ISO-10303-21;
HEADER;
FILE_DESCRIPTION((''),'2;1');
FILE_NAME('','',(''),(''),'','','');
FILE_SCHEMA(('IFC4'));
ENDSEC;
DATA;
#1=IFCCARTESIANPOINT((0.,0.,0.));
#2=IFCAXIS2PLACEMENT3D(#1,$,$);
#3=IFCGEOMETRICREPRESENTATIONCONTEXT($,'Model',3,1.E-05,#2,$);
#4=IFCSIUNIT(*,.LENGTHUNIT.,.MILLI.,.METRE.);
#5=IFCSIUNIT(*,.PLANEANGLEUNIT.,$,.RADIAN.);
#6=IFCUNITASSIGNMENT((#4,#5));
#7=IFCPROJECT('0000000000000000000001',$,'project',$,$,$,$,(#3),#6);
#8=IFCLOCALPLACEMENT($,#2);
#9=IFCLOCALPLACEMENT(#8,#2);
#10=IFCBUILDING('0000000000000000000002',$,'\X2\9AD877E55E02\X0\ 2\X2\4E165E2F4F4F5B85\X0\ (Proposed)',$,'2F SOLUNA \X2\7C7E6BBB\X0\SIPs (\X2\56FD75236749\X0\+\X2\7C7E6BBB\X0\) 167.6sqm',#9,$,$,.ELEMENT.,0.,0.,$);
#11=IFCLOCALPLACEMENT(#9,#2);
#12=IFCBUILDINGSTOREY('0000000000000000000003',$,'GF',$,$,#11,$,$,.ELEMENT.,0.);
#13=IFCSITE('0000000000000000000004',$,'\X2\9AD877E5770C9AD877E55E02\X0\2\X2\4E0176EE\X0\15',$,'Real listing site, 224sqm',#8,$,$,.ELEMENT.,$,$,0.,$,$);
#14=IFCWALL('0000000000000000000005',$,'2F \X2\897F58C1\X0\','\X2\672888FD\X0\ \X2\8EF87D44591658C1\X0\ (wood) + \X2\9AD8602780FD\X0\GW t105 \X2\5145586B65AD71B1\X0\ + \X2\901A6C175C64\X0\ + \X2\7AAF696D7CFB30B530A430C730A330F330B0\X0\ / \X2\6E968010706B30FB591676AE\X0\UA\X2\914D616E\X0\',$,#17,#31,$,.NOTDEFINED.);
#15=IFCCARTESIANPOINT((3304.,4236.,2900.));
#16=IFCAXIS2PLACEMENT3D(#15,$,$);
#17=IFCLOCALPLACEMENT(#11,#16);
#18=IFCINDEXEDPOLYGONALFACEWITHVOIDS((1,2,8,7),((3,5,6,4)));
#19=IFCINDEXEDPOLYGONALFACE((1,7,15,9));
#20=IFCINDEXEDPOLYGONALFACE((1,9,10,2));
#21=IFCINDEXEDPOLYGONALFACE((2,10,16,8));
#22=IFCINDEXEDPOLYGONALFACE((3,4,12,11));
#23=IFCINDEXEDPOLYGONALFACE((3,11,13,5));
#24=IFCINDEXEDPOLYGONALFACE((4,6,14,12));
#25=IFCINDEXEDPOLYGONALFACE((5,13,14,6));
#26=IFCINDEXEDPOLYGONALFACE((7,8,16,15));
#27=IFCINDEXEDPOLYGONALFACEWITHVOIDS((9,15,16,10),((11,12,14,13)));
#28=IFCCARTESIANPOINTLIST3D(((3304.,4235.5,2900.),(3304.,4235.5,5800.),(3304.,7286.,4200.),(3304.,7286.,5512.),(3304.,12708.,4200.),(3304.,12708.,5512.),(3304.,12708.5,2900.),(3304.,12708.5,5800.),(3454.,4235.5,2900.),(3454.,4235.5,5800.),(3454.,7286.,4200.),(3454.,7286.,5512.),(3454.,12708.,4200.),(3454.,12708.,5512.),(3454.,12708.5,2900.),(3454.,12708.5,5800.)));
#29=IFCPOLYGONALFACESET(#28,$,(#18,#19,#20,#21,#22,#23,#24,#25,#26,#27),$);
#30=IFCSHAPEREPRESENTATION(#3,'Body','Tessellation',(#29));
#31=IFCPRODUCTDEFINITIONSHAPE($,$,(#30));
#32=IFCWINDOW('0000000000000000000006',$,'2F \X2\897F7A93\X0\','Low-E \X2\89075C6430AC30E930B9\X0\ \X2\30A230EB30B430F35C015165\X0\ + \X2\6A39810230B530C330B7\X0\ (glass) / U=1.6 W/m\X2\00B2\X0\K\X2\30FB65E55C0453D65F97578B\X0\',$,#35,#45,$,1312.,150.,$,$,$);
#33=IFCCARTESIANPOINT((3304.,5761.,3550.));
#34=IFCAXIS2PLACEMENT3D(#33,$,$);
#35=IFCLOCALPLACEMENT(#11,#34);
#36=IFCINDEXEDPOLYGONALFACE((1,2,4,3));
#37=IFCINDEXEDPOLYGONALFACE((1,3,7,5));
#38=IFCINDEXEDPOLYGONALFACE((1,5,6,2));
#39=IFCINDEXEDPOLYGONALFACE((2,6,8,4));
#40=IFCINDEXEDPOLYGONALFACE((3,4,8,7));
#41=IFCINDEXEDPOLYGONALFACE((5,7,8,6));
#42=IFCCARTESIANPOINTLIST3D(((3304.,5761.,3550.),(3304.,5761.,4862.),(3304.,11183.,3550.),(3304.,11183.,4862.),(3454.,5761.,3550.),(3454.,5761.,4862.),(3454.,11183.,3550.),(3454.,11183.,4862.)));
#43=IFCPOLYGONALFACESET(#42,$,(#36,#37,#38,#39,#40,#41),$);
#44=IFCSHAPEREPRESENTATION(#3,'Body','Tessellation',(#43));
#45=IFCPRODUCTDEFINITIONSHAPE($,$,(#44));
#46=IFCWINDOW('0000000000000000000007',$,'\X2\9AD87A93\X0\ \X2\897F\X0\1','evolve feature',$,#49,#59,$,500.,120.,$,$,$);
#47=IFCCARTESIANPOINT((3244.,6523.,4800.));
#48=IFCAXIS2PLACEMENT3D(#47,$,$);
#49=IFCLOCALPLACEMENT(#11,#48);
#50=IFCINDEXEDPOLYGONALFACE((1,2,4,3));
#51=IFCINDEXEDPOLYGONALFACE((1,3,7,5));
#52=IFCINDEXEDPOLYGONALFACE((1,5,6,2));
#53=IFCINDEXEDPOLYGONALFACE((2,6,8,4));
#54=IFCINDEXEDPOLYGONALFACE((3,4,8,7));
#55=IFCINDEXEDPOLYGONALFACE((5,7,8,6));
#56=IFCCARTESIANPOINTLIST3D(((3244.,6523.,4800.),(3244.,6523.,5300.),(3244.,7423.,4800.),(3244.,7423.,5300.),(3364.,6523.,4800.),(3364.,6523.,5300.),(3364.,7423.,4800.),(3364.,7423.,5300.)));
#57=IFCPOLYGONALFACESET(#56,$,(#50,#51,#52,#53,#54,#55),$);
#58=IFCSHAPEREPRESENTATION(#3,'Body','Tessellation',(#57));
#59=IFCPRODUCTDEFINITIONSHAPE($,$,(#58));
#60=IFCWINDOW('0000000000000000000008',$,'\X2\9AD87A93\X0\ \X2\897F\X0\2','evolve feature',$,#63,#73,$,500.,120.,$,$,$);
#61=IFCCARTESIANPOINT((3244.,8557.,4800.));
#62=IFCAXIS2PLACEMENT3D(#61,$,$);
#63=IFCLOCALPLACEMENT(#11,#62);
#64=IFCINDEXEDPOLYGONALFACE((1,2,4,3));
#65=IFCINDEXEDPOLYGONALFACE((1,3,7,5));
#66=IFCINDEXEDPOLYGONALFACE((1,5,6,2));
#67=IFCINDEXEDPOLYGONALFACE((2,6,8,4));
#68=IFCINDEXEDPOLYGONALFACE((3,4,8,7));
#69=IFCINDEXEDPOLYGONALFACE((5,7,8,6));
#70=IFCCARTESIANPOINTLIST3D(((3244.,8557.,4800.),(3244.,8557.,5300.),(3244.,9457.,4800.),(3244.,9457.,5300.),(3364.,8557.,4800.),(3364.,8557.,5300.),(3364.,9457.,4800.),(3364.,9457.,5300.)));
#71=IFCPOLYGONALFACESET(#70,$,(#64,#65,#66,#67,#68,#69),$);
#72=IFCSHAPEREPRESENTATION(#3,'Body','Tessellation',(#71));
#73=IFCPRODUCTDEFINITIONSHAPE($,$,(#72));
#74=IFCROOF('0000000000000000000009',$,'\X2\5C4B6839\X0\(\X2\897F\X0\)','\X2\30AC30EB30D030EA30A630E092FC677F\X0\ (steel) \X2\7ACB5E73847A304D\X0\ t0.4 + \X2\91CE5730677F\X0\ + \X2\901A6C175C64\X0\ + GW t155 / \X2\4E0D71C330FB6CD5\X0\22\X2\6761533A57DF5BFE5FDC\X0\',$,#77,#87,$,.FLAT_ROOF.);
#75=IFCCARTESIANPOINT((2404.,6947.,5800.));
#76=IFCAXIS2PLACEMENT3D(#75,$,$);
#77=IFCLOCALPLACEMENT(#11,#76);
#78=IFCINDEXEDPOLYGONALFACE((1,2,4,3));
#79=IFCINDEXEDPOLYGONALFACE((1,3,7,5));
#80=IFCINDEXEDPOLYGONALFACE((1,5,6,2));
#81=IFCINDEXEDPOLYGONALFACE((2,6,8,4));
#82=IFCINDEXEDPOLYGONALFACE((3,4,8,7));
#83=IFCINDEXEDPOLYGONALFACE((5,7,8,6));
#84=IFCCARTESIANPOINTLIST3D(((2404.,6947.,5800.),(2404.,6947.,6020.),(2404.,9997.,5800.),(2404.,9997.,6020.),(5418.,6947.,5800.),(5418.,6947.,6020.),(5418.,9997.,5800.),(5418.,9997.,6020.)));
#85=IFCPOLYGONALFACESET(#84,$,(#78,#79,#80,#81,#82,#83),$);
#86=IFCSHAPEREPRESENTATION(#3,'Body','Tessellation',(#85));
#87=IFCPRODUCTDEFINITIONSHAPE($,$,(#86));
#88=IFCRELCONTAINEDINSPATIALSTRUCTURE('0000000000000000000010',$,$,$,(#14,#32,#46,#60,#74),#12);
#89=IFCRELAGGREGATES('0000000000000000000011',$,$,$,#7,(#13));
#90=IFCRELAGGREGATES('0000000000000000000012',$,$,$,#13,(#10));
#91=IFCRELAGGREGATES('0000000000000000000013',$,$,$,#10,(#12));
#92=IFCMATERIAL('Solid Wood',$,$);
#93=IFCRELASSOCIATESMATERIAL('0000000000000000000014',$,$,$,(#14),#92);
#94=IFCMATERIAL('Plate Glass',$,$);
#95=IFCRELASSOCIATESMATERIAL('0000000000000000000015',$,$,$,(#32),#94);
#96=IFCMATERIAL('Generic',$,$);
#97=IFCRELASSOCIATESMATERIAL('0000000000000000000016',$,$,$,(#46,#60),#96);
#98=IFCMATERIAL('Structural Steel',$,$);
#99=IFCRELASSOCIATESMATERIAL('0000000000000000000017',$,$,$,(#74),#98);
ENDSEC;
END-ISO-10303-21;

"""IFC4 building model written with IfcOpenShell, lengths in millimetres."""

from ifc_helpers import new_model, si_unit, frame, frame_2d, origin, place, context, project, spatial, rectangle, extrude, material, element, fill, save


model = new_model("IFC4")

# Units and contexts
model_context = context("Model", 3, precision=1e-05, world=origin())
ifc_project = project(units=[si_unit("LENGTHUNIT", "METRE", prefix="MILLI"), si_unit("PLANEANGLEUNIT", "RADIAN")], contexts=[model_context])

# Site, building, storey
site_placement = place(None, origin())
site = spatial("IfcSite", under=ifc_project, at=site_placement, Name="高知県高知市2丁目15", ObjectType="Real listing site, 224sqm", CompositionType="ELEMENT", RefElevation=0.0)
building_placement = place(site_placement, origin())
building = spatial("IfcBuilding", under=site, at=building_placement, Name="高知市 2世帯住宅 (Proposed)", ObjectType="2F SOLUNA 籾殻SIPs (国産杉+籾殻) 167.6sqm", CompositionType="ELEMENT", ElevationOfRefHeight=0.0, ElevationOfTerrain=0.0)
storey_placement = place(building_placement, origin())
storey = spatial("IfcBuildingStorey", under=building, at=storey_placement, Name="GF", CompositionType="ELEMENT", Elevation=0.0)

# Shared definitions
ifc_material_1 = material(Name="Solid Wood")
ifc_material_2 = material(Name="Generic")

# Shared definitions
ifc_material_3 = material(Name="Plate Glass")

# Wall, openings, windows
wall_1_placement = place(storey_placement, frame((3304.0, 4236.0, 2900.0)))
wall_1 = element("IfcWall", 1, at=wall_1_placement, inside=storey, material=ifc_material_1, Name="2F 西壁", Description="木製 軸組外壁 (wood) + 高性能GW t105 充填断熱 + 通気層 + 窯業系サイディング / 準耐火・外皮UA配慮", PredefinedType="NOTDEFINED", context=model_context, shape_type="SweptSolid", body=[
    extrude(rectangle(XDim=150.0, YDim=8473.0, at=frame_2d((75.0, 4236.0))), frame((3304.0, 4236.0, 2900.0)), (0.0, 0.0, 1.0), 2900.0),
])
opening_1_placement = place(storey_placement, frame((3304.0, 5761.0, 3550.0)))
opening_1 = element("IfcOpeningElement", 2, at=opening_1_placement, cuts=wall_1, PredefinedType="NOTDEFINED", context=model_context, shape_type="SweptSolid", body=[
    extrude(rectangle(XDim=150.0, YDim=5422.0, at=frame_2d((75.0, 2711.0))), frame((3304.0, 5761.0, 3550.0)), (0.0, 0.0, 1.0), 1312.0),
])
opening_2_placement = place(storey_placement, frame((3244.0, 6523.0, 4800.0)))
opening_2 = element("IfcOpeningElement", 3, at=opening_2_placement, cuts=wall_1, PredefinedType="NOTDEFINED", context=model_context, shape_type="SweptSolid", body=[
    extrude(rectangle(XDim=120.0, YDim=900.0, at=frame_2d((60.0, 450.0))), frame((3244.0, 6523.0, 4800.0)), (0.0, 0.0, 1.0), 500.0),
])
opening_3_placement = place(storey_placement, frame((3244.0, 8557.0, 4800.0)))
opening_3 = element("IfcOpeningElement", 4, at=opening_3_placement, cuts=wall_1, PredefinedType="NOTDEFINED", context=model_context, shape_type="SweptSolid", body=[
    extrude(rectangle(XDim=120.0, YDim=900.0, at=frame_2d((60.0, 450.0))), frame((3244.0, 8557.0, 4800.0)), (0.0, 0.0, 1.0), 500.0),
])
window_1_placement = place(storey_placement, frame((3304.0, 5761.0, 3550.0)))
window_1 = element("IfcWindow", 5, at=window_1_placement, inside=storey, material=ifc_material_3, Name="2F 西窓", Description="Low-E 複層ガラス アルゴン封入 + 樹脂サッシ (glass) / U=1.6 W/m²K・日射取得型", OverallHeight=1312.0, OverallWidth=150.0, context=model_context, shape_type="SweptSolid", body=[
    extrude(rectangle(XDim=150.0, YDim=5422.0, at=frame_2d((75.0, 2711.0))), frame((3304.0, 5761.0, 3550.0)), (0.0, 0.0, 1.0), 1312.0),
])
fill(opening_1, window_1)
window_2_placement = place(storey_placement, frame((3244.0, 6523.0, 4800.0)))
window_2 = element("IfcWindow", 6, at=window_2_placement, inside=storey, material=ifc_material_2, Name="高窓 西1", Description="evolve feature", OverallHeight=500.0, OverallWidth=120.0, context=model_context, shape_type="SweptSolid", body=[
    extrude(rectangle(XDim=120.0, YDim=900.0, at=frame_2d((60.0, 450.0))), frame((3244.0, 6523.0, 4800.0)), (0.0, 0.0, 1.0), 500.0),
])
fill(opening_2, window_2)
window_3_placement = place(storey_placement, frame((3244.0, 8557.0, 4800.0)))
window_3 = element("IfcWindow", 7, at=window_3_placement, inside=storey, material=ifc_material_2, Name="高窓 西2", Description="evolve feature", OverallHeight=500.0, OverallWidth=120.0, context=model_context, shape_type="SweptSolid", body=[
    extrude(rectangle(XDim=120.0, YDim=900.0, at=frame_2d((60.0, 450.0))), frame((3244.0, 8557.0, 4800.0)), (0.0, 0.0, 1.0), 500.0),
])
fill(opening_3, window_3)

# Roof
ifc_material_4 = material(Name="Structural Steel")
roof_1_placement = place(storey_placement, frame((2404.0, 6947.0, 5800.0)))
element("IfcRoof", 8, at=roof_1_placement, inside=storey, material=ifc_material_4, Name="屋根(西)", Description="ガルバリウム鋼板 (steel) 立平葺き t0.4 + 野地板 + 通気層 + GW t155 / 不燃・法22条区域対応", PredefinedType="FLAT_ROOF", context=model_context, shape_type="SweptSolid", body=[
    extrude(rectangle(XDim=3014.0, YDim=3050.0, at=frame_2d((1507.0, 1525.0))), frame((2404.0, 6947.0, 5800.0)), (0.0, 0.0, 1.0), 220.0),
])

save(model, "model.ifc")
